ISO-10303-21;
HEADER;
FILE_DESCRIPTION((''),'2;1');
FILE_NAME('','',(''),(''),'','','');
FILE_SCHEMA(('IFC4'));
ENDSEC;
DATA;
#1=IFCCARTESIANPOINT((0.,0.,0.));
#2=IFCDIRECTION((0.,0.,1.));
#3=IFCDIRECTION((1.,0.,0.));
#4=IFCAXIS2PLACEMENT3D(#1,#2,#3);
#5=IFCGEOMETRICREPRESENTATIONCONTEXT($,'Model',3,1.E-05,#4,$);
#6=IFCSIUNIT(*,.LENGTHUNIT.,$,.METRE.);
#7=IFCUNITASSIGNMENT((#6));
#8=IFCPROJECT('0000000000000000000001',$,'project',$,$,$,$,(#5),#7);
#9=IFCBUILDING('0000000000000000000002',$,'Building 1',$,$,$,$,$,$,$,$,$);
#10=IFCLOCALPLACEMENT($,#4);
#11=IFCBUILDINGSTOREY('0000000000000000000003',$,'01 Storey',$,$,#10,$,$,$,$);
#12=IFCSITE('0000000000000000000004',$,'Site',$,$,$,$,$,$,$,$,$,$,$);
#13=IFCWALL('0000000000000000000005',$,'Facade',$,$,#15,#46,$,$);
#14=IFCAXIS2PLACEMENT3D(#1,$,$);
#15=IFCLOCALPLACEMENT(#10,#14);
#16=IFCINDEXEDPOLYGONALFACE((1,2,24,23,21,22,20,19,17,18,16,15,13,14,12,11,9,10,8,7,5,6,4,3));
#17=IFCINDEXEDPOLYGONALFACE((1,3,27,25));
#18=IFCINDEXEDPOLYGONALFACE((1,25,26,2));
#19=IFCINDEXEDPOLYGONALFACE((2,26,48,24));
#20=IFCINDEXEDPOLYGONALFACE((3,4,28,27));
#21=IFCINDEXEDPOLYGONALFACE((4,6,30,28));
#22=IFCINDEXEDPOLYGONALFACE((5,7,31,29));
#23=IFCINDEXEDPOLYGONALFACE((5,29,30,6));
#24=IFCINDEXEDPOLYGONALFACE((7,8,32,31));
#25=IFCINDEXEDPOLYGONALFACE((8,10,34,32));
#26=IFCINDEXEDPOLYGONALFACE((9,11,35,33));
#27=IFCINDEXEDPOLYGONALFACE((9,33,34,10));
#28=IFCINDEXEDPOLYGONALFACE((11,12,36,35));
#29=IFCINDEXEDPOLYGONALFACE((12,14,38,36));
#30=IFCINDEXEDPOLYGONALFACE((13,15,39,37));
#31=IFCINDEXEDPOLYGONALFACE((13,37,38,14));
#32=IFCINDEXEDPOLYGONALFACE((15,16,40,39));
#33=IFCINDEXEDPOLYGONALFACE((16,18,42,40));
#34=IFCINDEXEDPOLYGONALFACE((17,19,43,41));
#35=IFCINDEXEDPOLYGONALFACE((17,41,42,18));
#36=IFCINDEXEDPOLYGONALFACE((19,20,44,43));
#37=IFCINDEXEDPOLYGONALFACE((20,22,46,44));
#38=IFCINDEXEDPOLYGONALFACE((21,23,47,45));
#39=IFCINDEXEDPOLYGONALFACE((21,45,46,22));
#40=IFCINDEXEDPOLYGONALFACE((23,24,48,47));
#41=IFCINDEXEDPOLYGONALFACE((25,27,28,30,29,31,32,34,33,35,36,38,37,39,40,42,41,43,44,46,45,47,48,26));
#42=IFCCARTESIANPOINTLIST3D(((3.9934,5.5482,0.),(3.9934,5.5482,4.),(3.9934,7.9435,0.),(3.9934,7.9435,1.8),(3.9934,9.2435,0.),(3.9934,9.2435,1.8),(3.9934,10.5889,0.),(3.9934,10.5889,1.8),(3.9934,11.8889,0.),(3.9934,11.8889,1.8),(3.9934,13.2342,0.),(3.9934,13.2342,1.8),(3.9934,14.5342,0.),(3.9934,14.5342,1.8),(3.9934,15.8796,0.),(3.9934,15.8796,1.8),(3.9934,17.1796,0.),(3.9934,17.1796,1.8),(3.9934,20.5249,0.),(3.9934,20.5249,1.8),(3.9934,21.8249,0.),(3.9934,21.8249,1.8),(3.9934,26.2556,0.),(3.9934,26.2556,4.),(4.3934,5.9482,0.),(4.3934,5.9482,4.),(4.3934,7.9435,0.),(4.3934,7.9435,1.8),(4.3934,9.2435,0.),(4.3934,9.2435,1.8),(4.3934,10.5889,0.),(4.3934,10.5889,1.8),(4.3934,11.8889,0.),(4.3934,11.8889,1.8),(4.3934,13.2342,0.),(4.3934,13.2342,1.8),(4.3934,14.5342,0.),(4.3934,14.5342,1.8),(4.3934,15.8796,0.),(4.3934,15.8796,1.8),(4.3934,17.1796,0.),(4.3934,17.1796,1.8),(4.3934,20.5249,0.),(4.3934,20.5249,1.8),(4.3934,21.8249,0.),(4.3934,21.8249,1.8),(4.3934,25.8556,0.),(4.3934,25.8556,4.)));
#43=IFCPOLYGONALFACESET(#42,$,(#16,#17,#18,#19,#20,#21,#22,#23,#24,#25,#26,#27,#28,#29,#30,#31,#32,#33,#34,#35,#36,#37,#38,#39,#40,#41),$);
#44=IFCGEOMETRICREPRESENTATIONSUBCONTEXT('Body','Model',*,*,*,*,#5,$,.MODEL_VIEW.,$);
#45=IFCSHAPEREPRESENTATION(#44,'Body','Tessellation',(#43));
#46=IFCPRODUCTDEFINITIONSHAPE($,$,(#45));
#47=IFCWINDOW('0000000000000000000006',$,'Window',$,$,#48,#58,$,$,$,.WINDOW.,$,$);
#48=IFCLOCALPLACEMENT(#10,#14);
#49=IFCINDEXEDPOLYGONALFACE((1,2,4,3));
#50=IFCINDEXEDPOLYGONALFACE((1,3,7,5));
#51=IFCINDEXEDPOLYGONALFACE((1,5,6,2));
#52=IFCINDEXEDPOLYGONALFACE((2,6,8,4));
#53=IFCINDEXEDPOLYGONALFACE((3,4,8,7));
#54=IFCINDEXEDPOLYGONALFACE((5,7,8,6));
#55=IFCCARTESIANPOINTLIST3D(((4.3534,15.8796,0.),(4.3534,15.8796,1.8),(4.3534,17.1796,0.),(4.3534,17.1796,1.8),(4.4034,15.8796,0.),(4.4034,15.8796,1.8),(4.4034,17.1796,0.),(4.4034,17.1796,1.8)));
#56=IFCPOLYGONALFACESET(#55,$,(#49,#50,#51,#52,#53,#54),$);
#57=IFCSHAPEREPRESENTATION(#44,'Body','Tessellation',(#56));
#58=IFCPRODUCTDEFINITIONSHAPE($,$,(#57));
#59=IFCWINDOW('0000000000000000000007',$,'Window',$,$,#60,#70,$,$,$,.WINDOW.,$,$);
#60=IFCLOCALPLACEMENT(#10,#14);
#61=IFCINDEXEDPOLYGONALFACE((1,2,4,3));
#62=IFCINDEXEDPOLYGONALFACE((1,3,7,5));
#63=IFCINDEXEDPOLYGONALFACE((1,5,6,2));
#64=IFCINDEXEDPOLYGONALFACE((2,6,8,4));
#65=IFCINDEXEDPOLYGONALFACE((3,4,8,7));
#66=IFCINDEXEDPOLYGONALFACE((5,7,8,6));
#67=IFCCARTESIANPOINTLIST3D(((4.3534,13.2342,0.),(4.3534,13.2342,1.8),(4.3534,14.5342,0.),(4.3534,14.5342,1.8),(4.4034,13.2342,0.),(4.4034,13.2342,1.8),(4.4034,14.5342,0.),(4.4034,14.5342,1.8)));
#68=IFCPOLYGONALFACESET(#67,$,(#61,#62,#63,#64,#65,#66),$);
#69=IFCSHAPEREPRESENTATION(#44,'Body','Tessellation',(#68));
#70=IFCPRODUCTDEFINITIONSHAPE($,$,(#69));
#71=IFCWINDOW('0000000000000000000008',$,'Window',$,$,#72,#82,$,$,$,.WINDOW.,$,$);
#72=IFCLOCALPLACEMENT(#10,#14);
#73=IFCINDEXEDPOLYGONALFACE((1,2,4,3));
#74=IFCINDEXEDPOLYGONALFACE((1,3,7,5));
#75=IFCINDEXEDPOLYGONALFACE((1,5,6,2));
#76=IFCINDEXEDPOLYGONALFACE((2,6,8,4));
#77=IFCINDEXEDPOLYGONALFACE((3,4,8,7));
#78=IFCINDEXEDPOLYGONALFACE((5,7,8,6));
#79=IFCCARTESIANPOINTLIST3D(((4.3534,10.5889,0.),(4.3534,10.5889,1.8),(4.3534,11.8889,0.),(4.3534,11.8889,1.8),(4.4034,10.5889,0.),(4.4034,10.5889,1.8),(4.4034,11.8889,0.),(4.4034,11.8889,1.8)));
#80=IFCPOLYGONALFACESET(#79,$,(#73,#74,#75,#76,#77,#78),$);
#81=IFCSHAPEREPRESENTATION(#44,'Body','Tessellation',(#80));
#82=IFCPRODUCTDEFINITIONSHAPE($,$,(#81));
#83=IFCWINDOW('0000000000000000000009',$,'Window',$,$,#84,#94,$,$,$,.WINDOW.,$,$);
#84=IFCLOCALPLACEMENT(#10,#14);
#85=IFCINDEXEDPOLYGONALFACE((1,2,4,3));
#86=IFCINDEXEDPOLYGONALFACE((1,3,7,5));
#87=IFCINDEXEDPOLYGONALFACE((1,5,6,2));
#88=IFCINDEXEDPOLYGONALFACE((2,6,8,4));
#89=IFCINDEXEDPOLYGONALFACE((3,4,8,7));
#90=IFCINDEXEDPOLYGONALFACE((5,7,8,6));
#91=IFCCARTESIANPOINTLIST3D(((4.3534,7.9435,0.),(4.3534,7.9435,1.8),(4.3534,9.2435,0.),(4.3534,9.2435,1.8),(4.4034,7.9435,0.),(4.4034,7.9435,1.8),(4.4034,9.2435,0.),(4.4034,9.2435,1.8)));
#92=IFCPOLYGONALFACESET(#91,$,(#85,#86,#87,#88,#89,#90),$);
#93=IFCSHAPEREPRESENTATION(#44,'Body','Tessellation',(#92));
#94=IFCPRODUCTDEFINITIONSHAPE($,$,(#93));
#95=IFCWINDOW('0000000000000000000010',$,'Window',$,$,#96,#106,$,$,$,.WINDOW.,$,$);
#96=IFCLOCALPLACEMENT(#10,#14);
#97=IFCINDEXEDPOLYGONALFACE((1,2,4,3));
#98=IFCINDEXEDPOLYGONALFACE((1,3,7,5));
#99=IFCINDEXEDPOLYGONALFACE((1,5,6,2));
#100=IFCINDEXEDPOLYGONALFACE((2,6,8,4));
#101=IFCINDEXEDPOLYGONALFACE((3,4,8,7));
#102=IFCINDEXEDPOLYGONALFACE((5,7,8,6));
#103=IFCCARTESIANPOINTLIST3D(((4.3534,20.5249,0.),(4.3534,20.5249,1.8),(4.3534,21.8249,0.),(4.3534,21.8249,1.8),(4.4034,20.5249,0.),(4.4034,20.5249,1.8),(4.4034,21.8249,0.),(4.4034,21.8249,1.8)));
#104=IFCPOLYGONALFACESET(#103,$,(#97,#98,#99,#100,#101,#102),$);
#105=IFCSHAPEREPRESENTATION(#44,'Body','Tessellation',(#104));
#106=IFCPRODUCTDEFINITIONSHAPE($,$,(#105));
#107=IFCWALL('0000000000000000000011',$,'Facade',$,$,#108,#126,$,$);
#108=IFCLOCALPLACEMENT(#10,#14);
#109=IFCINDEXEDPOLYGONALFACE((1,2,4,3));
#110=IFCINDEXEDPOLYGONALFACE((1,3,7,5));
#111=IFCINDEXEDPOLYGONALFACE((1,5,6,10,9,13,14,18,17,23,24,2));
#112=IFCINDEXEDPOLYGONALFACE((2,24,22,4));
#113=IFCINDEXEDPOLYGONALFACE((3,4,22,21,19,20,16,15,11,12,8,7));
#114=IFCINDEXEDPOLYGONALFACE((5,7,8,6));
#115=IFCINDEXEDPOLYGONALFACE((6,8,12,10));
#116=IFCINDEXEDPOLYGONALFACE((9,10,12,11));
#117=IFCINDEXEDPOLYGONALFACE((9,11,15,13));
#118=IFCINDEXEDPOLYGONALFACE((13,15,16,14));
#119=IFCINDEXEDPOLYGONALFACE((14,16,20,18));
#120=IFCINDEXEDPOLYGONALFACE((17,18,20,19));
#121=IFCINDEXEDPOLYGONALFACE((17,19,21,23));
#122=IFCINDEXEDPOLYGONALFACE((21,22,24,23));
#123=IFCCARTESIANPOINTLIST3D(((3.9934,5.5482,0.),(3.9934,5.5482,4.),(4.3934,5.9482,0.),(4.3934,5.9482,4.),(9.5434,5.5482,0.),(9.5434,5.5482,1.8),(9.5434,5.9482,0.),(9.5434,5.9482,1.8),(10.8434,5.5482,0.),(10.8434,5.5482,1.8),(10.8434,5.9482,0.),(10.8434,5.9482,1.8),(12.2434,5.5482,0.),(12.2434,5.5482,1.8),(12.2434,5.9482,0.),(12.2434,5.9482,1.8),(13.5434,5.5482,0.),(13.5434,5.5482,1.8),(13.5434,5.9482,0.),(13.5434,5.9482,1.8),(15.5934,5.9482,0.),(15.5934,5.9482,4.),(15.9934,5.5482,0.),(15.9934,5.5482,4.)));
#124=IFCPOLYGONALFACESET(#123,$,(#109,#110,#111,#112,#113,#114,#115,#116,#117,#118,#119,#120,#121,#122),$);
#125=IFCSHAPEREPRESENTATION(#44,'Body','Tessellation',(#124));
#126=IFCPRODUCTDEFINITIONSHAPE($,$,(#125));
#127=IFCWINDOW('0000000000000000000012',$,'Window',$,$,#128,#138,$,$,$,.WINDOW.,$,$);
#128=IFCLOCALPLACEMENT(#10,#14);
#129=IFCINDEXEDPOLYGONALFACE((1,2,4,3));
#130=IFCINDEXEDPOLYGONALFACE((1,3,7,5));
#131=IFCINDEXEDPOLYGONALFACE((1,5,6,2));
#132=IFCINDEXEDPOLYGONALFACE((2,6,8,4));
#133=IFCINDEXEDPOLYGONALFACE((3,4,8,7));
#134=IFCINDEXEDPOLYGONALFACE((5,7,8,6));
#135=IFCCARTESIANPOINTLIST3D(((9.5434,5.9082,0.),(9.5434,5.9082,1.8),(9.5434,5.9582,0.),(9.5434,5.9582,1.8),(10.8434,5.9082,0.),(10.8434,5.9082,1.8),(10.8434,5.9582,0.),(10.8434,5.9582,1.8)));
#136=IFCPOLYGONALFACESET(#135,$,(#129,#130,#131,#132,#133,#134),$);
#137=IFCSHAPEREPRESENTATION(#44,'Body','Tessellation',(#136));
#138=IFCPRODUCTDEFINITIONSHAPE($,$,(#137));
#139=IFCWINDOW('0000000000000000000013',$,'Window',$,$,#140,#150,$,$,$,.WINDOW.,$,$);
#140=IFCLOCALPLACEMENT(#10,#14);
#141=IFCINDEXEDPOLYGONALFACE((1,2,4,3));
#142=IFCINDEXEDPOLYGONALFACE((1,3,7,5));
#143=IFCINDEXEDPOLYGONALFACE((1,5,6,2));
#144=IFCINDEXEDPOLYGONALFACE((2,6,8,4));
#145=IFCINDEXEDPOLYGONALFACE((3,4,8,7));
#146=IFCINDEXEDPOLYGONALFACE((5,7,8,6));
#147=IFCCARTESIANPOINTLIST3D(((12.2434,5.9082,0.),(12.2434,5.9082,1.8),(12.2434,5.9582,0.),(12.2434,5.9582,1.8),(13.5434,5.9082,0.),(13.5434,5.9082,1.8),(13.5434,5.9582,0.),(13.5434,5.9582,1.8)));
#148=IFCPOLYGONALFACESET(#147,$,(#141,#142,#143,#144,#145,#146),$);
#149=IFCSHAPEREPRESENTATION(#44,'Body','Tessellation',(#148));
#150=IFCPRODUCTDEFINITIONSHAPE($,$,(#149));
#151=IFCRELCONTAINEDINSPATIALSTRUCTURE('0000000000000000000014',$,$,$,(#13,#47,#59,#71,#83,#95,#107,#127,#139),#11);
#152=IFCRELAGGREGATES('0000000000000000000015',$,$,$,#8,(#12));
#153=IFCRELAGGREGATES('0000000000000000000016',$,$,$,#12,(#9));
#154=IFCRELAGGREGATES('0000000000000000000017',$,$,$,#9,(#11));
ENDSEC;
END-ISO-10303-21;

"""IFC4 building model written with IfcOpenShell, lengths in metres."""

from ifc_helpers import new_model, si_unit, origin_with_axes, place, context, subcontext, project, spatial, line, indexed_curve, outline, extrude, element, fill, save


model = new_model("IFC4")

# Units and contexts
model_context = context("Model", 3, precision=1e-05, world=origin_with_axes())
body_context = subcontext(model_context, "Body", "Model", "MODEL_VIEW")
ifc_project = project(units=[si_unit("LENGTHUNIT", "METRE")], contexts=[model_context])

# Site, building, storey
site = spatial("IfcSite", under=ifc_project, Name="Site")
building = spatial("IfcBuilding", under=site, Name="Building 1")
storey_placement = place(None, origin_with_axes())
storey = spatial("IfcBuildingStorey", under=building, at=storey_placement, Name="01 Storey")

# Walls, openings, windows
wall_1_placement = place(storey_placement, origin_with_axes())
wall_1 = element("IfcWall", 1, at=wall_1_placement, inside=storey, Name="Facade", context=body_context, shape_type="SweptSolid", body=[
    extrude(outline(indexed_curve([(4.3934, 25.8556), (4.3934, 5.9482), (3.9934, 5.5482), (3.9934, 26.2556)], segments=[line(1, 2), line(2, 3), line(3, 4)])), origin_with_axes(), (0.0, 0.0, 1.0), 4.0),
])
opening_1_placement = place(wall_1_placement, origin_with_axes())
opening_1 = element("IfcOpeningElement", 2, at=opening_1_placement, cuts=wall_1, context=body_context, shape_type="SweptSolid", body=[
    extrude(outline(indexed_curve([(3.9534, 17.1796), (4.4534, 17.1796), (4.4534, 15.8796), (3.9534, 15.8796)], segments=[line(1, 2), line(2, 3), line(3, 4)])), origin_with_axes(), (0.0, 0.0, 1.0), 1.8),
])
opening_2_placement = place(wall_1_placement, origin_with_axes())
opening_2 = element("IfcOpeningElement", 3, at=opening_2_placement, cuts=wall_1, context=body_context, shape_type="SweptSolid", body=[
    extrude(outline(indexed_curve([(3.9534, 14.5342), (4.4534, 14.5342), (4.4534, 13.2342), (3.9534, 13.2342)], segments=[line(1, 2), line(2, 3), line(3, 4)])), origin_with_axes(), (0.0, 0.0, 1.0), 1.8),
])
opening_3_placement = place(wall_1_placement, origin_with_axes())
opening_3 = element("IfcOpeningElement", 4, at=opening_3_placement, cuts=wall_1, context=body_context, shape_type="SweptSolid", body=[
    extrude(outline(indexed_curve([(3.9534, 11.8889), (4.4534, 11.8889), (4.4534, 10.5889), (3.9534, 10.5889)], segments=[line(1, 2), line(2, 3), line(3, 4)])), origin_with_axes(), (0.0, 0.0, 1.0), 1.8),
])
opening_4_placement = place(wall_1_placement, origin_with_axes())
opening_4 = element("IfcOpeningElement", 5, at=opening_4_placement, cuts=wall_1, context=body_context, shape_type="SweptSolid", body=[
    extrude(outline(indexed_curve([(3.9534, 9.2435), (4.4534, 9.2435), (4.4534, 7.9435), (3.9534, 7.9435)], segments=[line(1, 2), line(2, 3), line(3, 4)])), origin_with_axes(), (0.0, 0.0, 1.0), 1.8),
])
opening_5_placement = place(wall_1_placement, origin_with_axes())
opening_5 = element("IfcOpeningElement", 6, at=opening_5_placement, cuts=wall_1, context=body_context, shape_type="SweptSolid", body=[
    extrude(outline(indexed_curve([(3.9534, 21.8249), (4.4534, 21.8249), (4.4534, 20.5249), (3.9534, 20.5249)], segments=[line(1, 2), line(2, 3), line(3, 4)])), origin_with_axes(), (0.0, 0.0, 1.0), 1.8),
])
window_1_placement = place(storey_placement, origin_with_axes())
window_1 = element("IfcWindow", 7, at=window_1_placement, inside=storey, Name="Window", PredefinedType="WINDOW", context=body_context, shape_type="SweptSolid", body=[
    extrude(outline(indexed_curve([(4.3534, 17.1796), (4.4034, 17.1796), (4.4034, 15.8796), (4.3534, 15.8796)], segments=[line(1, 2), line(2, 3), line(3, 4)])), origin_with_axes(), (0.0, 0.0, 1.0), 1.8),
])
fill(opening_1, window_1)
window_2_placement = place(storey_placement, origin_with_axes())
window_2 = element("IfcWindow", 8, at=window_2_placement, inside=storey, Name="Window", PredefinedType="WINDOW", context=body_context, shape_type="SweptSolid", body=[
    extrude(outline(indexed_curve([(4.3534, 14.5342), (4.4034, 14.5342), (4.4034, 13.2342), (4.3534, 13.2342)], segments=[line(1, 2), line(2, 3), line(3, 4)])), origin_with_axes(), (0.0, 0.0, 1.0), 1.8),
])
fill(opening_2, window_2)
window_3_placement = place(storey_placement, origin_with_axes())
window_3 = element("IfcWindow", 9, at=window_3_placement, inside=storey, Name="Window", PredefinedType="WINDOW", context=body_context, shape_type="SweptSolid", body=[
    extrude(outline(indexed_curve([(4.3534, 11.8889), (4.4034, 11.8889), (4.4034, 10.5889), (4.3534, 10.5889)], segments=[line(1, 2), line(2, 3), line(3, 4)])), origin_with_axes(), (0.0, 0.0, 1.0), 1.8),
])
fill(opening_3, window_3)
window_4_placement = place(storey_placement, origin_with_axes())
window_4 = element("IfcWindow", 10, at=window_4_placement, inside=storey, Name="Window", PredefinedType="WINDOW", context=body_context, shape_type="SweptSolid", body=[
    extrude(outline(indexed_curve([(4.3534, 9.2435), (4.4034, 9.2435), (4.4034, 7.9435), (4.3534, 7.9435)], segments=[line(1, 2), line(2, 3), line(3, 4)])), origin_with_axes(), (0.0, 0.0, 1.0), 1.8),
])
fill(opening_4, window_4)
window_5_placement = place(storey_placement, origin_with_axes())
window_5 = element("IfcWindow", 11, at=window_5_placement, inside=storey, Name="Window", PredefinedType="WINDOW", context=body_context, shape_type="SweptSolid", body=[
    extrude(outline(indexed_curve([(4.3534, 21.8249), (4.4034, 21.8249), (4.4034, 20.5249), (4.3534, 20.5249)], segments=[line(1, 2), line(2, 3), line(3, 4)])), origin_with_axes(), (0.0, 0.0, 1.0), 1.8),
])
fill(opening_5, window_5)
wall_2_placement = place(storey_placement, origin_with_axes())
wall_2 = element("IfcWall", 12, at=wall_2_placement, inside=storey, Name="Facade", context=body_context, shape_type="SweptSolid", body=[
    extrude(outline(indexed_curve([(4.3934, 5.9482), (15.5934, 5.9482), (15.9934, 5.5482), (3.9934, 5.5482)], segments=[line(1, 2), line(2, 3), line(3, 4)])), origin_with_axes(), (0.0, 0.0, 1.0), 4.0),
])
opening_6_placement = place(wall_2_placement, origin_with_axes())
opening_6 = element("IfcOpeningElement", 13, at=opening_6_placement, cuts=wall_2, context=body_context, shape_type="SweptSolid", body=[
    extrude(outline(indexed_curve([(9.5434, 5.5082), (9.5434, 6.0082), (10.8434, 6.0082), (10.8434, 5.5082)], segments=[line(1, 2), line(2, 3), line(3, 4)])), origin_with_axes(), (0.0, 0.0, 1.0), 1.8),
])
opening_7_placement = place(wall_2_placement, origin_with_axes())
opening_7 = element("IfcOpeningElement", 14, at=opening_7_placement, cuts=wall_2, context=body_context, shape_type="SweptSolid", body=[
    extrude(outline(indexed_curve([(12.2434, 5.5082), (12.2434, 6.0082), (13.5434, 6.0082), (13.5434, 5.5082)], segments=[line(1, 2), line(2, 3), line(3, 4)])), origin_with_axes(), (0.0, 0.0, 1.0), 1.8),
])
window_6_placement = place(storey_placement, origin_with_axes())
window_6 = element("IfcWindow", 15, at=window_6_placement, inside=storey, Name="Window", PredefinedType="WINDOW", context=body_context, shape_type="SweptSolid", body=[
    extrude(outline(indexed_curve([(9.5434, 5.9082), (9.5434, 5.9582), (10.8434, 5.9582), (10.8434, 5.9082)], segments=[line(1, 2), line(2, 3), line(3, 4)])), origin_with_axes(), (0.0, 0.0, 1.0), 1.8),
])
fill(opening_6, window_6)
window_7_placement = place(storey_placement, origin_with_axes())
window_7 = element("IfcWindow", 16, at=window_7_placement, inside=storey, Name="Window", PredefinedType="WINDOW", context=body_context, shape_type="SweptSolid", body=[
    extrude(outline(indexed_curve([(12.2434, 5.9082), (12.2434, 5.9582), (13.5434, 5.9582), (13.5434, 5.9082)], segments=[line(1, 2), line(2, 3), line(3, 4)])), origin_with_axes(), (0.0, 0.0, 1.0), 1.8),
])
fill(opening_7, window_7)

save(model, "model.ifc")
